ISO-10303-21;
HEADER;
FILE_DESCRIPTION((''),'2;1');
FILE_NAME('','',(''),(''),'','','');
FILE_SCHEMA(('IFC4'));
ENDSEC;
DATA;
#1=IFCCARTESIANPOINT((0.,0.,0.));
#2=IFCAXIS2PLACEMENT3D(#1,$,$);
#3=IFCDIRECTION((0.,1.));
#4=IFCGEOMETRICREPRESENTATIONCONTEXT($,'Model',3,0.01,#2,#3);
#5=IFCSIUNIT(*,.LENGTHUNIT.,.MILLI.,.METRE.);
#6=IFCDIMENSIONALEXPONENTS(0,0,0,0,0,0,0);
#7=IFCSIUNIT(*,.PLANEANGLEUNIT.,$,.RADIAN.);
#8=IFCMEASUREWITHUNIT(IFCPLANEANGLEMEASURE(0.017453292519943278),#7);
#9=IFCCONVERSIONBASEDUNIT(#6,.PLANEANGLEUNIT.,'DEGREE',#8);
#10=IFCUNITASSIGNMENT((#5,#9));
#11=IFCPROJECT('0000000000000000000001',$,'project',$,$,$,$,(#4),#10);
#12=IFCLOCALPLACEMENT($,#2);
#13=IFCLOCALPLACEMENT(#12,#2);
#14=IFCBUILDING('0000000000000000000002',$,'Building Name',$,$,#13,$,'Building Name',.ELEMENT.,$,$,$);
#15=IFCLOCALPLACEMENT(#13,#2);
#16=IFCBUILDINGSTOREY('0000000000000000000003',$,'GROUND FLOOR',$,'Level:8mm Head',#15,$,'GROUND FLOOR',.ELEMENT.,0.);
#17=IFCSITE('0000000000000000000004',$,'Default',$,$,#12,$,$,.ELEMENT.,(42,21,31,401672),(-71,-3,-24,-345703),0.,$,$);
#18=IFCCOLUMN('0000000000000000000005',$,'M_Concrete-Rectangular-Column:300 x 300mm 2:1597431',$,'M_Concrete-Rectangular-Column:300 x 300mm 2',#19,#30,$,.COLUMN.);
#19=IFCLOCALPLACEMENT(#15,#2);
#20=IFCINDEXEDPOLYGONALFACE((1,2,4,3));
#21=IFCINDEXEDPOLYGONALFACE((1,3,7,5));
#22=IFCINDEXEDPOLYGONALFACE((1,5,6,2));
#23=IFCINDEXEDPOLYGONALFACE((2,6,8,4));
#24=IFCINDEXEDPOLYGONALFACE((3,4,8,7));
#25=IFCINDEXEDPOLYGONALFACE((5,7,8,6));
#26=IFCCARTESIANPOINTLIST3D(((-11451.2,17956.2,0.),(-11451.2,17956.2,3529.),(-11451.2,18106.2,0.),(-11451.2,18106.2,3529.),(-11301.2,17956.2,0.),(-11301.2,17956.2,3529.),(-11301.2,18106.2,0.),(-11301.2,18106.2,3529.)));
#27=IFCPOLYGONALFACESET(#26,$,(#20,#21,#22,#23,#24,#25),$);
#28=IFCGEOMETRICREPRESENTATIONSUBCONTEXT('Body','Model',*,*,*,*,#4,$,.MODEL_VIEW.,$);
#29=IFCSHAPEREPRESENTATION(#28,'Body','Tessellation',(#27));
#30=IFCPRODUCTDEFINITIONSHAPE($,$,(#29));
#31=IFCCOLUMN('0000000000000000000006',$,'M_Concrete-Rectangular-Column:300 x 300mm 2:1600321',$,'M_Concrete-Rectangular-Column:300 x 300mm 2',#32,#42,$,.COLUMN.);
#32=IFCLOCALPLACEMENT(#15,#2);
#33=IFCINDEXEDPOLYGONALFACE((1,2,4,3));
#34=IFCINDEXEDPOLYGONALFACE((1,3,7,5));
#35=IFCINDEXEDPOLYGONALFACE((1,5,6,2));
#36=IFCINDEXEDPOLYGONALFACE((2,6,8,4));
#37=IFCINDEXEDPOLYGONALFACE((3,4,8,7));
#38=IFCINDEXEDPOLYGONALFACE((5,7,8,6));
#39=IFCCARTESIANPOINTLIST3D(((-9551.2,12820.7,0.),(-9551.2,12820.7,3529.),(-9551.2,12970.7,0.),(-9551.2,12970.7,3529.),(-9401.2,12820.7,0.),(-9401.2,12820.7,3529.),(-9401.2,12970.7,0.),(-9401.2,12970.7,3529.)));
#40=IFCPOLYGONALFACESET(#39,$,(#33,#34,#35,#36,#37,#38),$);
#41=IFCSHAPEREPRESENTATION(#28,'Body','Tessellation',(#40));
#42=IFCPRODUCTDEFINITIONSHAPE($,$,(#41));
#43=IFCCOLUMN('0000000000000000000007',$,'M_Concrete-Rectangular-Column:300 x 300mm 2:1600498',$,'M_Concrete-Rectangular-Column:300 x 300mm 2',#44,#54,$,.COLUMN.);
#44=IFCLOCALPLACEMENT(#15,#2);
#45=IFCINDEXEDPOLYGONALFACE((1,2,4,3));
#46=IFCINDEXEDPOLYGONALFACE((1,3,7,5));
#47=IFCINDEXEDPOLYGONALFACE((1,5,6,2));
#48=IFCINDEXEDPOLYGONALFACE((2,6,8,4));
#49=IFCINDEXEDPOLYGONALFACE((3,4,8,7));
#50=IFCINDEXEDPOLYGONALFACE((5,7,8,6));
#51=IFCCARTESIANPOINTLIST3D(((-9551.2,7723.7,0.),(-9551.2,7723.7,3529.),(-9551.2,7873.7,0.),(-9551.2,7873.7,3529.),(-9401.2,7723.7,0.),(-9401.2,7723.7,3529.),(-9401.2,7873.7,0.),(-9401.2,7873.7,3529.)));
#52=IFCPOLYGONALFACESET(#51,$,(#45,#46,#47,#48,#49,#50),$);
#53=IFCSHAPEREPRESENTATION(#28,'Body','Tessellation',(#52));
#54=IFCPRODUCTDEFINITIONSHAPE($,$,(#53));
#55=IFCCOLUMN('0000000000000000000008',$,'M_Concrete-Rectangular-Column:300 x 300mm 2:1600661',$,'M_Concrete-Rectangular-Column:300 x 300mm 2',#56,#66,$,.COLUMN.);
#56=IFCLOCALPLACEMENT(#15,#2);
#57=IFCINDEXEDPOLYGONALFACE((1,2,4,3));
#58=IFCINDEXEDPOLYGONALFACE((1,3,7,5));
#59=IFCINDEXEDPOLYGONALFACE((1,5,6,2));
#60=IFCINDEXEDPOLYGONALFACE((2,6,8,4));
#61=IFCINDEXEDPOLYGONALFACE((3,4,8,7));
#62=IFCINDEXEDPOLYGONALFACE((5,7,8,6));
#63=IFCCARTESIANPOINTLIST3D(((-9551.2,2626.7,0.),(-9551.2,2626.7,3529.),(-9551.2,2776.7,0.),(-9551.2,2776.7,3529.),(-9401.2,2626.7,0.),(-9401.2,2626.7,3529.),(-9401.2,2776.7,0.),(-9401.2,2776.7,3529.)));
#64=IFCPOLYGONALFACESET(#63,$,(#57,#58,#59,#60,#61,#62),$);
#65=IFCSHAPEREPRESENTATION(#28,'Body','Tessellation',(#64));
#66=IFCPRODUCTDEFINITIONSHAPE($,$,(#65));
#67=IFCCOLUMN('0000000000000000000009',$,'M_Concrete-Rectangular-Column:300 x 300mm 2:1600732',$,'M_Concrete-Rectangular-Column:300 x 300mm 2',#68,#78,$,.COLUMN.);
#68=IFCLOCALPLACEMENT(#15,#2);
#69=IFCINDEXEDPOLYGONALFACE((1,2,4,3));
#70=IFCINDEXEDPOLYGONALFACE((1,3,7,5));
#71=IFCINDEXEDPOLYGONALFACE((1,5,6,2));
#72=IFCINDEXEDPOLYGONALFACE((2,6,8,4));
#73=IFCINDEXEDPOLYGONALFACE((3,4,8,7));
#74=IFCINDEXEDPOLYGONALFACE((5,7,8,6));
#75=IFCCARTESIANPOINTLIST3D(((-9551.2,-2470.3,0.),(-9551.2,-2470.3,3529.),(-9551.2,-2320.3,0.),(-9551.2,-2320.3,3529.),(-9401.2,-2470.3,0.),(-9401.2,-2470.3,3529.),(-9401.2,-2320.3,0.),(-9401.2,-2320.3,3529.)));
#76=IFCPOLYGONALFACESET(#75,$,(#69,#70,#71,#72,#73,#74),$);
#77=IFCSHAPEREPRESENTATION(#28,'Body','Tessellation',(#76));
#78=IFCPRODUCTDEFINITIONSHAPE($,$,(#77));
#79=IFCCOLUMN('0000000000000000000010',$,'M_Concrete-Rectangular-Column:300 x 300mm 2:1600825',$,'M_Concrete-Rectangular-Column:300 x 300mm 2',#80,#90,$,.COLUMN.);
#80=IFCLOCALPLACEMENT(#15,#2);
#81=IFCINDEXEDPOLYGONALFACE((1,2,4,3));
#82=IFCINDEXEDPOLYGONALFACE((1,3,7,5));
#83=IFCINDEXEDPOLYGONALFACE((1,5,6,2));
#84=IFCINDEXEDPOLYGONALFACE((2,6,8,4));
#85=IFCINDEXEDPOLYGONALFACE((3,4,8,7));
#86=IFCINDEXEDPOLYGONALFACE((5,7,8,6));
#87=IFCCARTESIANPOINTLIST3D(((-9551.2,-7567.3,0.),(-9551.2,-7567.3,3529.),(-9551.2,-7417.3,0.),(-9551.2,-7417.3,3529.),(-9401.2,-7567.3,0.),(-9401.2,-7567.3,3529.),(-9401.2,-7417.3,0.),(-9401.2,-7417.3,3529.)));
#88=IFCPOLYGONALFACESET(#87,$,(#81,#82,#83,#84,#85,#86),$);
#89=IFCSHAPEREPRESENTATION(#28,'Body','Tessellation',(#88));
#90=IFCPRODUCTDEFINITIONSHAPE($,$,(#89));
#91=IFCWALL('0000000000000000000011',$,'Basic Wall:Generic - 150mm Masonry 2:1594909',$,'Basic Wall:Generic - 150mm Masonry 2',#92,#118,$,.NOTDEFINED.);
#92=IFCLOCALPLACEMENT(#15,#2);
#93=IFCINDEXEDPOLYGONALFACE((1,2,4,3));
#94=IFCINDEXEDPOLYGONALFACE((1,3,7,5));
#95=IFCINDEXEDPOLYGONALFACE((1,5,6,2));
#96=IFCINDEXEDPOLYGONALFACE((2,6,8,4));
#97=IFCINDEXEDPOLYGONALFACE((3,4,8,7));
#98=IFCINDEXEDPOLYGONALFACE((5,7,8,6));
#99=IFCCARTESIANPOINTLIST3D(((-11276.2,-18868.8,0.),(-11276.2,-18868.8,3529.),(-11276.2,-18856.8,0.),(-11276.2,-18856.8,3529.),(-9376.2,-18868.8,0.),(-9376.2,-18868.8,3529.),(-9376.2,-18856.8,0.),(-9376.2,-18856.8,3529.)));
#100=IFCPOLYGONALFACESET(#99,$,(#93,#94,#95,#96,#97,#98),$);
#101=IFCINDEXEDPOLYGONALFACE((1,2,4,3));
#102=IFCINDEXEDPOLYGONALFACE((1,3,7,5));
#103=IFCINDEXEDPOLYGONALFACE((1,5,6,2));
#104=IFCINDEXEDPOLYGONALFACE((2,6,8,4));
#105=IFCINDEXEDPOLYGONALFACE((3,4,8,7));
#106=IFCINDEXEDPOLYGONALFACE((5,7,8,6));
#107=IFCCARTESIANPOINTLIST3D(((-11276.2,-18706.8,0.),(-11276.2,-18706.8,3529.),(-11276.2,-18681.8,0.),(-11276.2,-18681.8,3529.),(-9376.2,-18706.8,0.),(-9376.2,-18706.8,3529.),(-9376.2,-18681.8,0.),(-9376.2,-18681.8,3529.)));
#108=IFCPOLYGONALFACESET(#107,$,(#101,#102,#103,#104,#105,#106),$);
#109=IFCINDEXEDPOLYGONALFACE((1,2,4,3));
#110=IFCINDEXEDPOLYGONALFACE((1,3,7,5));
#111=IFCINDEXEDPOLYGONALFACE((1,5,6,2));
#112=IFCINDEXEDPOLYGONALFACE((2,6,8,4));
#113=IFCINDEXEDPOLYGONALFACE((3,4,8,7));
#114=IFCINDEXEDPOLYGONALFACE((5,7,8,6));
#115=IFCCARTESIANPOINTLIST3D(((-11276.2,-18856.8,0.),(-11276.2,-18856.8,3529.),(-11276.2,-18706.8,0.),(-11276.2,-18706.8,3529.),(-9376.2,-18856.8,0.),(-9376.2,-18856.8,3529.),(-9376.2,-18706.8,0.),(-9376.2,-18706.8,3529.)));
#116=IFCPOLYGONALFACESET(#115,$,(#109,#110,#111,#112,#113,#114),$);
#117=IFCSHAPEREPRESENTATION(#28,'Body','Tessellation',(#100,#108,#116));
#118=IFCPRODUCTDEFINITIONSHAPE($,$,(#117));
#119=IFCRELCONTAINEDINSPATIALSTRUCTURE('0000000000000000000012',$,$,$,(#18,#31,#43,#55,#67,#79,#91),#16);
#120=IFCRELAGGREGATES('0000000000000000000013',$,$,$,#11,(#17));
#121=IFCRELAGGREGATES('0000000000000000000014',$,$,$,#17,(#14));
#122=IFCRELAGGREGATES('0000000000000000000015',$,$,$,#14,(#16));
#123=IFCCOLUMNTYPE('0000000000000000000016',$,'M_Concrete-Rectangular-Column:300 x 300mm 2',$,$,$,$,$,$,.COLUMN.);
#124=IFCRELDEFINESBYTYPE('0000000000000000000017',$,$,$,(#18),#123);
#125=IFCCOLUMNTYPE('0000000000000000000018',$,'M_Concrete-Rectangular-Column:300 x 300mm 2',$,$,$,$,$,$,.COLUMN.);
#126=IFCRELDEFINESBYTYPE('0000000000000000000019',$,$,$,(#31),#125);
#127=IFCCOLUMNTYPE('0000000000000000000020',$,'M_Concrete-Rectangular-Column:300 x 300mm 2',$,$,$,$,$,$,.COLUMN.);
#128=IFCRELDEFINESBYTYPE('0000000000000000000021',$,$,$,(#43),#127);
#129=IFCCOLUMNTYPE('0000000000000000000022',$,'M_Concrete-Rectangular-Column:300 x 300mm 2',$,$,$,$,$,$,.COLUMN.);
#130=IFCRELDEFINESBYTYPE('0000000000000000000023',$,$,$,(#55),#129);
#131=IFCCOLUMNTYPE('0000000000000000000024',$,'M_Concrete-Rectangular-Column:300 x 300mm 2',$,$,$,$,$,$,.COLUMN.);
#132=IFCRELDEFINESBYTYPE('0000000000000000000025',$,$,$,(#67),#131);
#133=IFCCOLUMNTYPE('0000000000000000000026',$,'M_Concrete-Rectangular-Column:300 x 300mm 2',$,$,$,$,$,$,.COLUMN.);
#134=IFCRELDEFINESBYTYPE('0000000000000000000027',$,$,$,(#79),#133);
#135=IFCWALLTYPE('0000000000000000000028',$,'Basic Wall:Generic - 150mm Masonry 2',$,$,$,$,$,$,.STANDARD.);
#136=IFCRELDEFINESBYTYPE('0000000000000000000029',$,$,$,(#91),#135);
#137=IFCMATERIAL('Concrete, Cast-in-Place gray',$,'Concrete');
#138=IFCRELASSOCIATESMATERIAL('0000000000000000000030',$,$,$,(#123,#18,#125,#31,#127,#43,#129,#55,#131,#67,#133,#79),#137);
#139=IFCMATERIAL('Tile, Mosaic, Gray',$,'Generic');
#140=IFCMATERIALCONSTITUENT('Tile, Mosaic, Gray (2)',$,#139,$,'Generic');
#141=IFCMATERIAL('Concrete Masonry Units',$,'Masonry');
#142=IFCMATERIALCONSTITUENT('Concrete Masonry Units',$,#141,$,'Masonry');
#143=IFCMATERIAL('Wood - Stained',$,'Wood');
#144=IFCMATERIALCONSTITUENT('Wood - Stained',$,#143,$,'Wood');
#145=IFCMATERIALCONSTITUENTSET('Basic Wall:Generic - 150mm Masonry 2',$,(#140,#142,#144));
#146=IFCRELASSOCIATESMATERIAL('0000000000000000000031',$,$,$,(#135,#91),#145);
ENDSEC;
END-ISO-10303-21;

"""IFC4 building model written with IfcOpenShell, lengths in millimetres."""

from ifc_helpers import new_model, entity, si_unit, converted_unit, direction, frame, origin, place, context, subcontext, project, spatial, indexed_curve, outline, extrude, source, transform, mapped, material, constituent, constituent_set, type_object, type_shapes, element, save


model = new_model("IFC4")

# Units and contexts
model_context = context("Model", 3, precision=0.01, world=origin(), true_north=direction((0.0, 1.0)))
body_context = subcontext(model_context, "Body", "Model", "MODEL_VIEW")
ifc_project = project(units=[si_unit("LENGTHUNIT", "METRE", prefix="MILLI"), converted_unit("PLANEANGLEUNIT", "DEGREE", entity("IfcPlaneAngleMeasure", 0.017453292519943278), si_unit("PLANEANGLEUNIT", "RADIAN"), dimensions=[0, 0, 0, 0, 0, 0, 0])], contexts=[model_context])

# Site, building, storey
site_placement = place(None, origin())
site = spatial("IfcSite", under=ifc_project, at=site_placement, Name="Default", CompositionType="ELEMENT", RefLatitude=(42, 21, 31, 401672), RefLongitude=(-71, -3, -24, -345703), RefElevation=0.0)
building_placement = place(site_placement, origin())
building = spatial("IfcBuilding", under=site, at=building_placement, Name="Building Name", LongName="Building Name", CompositionType="ELEMENT")
storey_placement = place(building_placement, origin())
storey = spatial("IfcBuildingStorey", under=building, at=storey_placement, Name="GROUND FLOOR", ObjectType="Level:8mm Head", LongName="GROUND FLOOR", CompositionType="ELEMENT", Elevation=0.0)

# Columns
ifc_material_1 = material(Name="Concrete, Cast-in-Place gray", Category="Concrete")
column_type_1 = type_object("IfcColumnType", Name="M_Concrete-Rectangular-Column:300 x 300mm 2", PredefinedType="COLUMN", material=ifc_material_1)
shared_shape_1 = source(origin(), body_context, "Body", "SweptSolid", [
    extrude(outline(indexed_curve([(-75.0, -75.0), (75.0, -75.0), (75.0, 75.0), (-75.0, 75.0), (-75.0, -75.0)], self_intersect=False)), frame((-11376.2, 18031.2, 0.0), z_axis=(0.0, 0.0, 1.0), x_axis=(-1.0, 0.0, 0.0)), (0.0, 0.0, 1.0), 3529.0),
])
type_shapes(column_type_1, [shared_shape_1])
column_1_placement = place(storey_placement, origin())
element("IfcColumn", 1, at=column_1_placement, inside=storey, type_object=column_type_1, material=ifc_material_1, Name="M_Concrete-Rectangular-Column:300 x 300mm 2:1597431", ObjectType="M_Concrete-Rectangular-Column:300 x 300mm 2", PredefinedType="COLUMN", context=body_context, shape_type="MappedRepresentation", body=[
    mapped(shared_shape_1, transform((0.0, 0.0, 0.0), scale=1.0)),
])
column_type_2 = type_object("IfcColumnType", Name="M_Concrete-Rectangular-Column:300 x 300mm 2", PredefinedType="COLUMN", material=ifc_material_1)
shared_shape_2 = source(origin(), body_context, "Body", "SweptSolid", [
    extrude(outline(indexed_curve([(-75.0, -75.0), (75.0, -75.0), (75.0, 75.0), (-75.0, 75.0), (-75.0, -75.0)], self_intersect=False)), frame((-9476.2, 12895.7, 0.0), z_axis=(0.0, 0.0, 1.0), x_axis=(-1.0, 0.0, 0.0)), (0.0, 0.0, 1.0), 3529.0),
])
type_shapes(column_type_2, [shared_shape_2])
column_2_placement = place(storey_placement, origin())
element("IfcColumn", 2, at=column_2_placement, inside=storey, type_object=column_type_2, material=ifc_material_1, Name="M_Concrete-Rectangular-Column:300 x 300mm 2:1600321", ObjectType="M_Concrete-Rectangular-Column:300 x 300mm 2", PredefinedType="COLUMN", context=body_context, shape_type="MappedRepresentation", body=[
    mapped(shared_shape_2, transform((0.0, 0.0, 0.0), scale=1.0)),
])
column_type_3 = type_object("IfcColumnType", Name="M_Concrete-Rectangular-Column:300 x 300mm 2", PredefinedType="COLUMN", material=ifc_material_1)
shared_shape_3 = source(origin(), body_context, "Body", "SweptSolid", [
    extrude(outline(indexed_curve([(-75.0, -75.0), (75.0, -75.0), (75.0, 75.0), (-75.0, 75.0), (-75.0, -75.0)], self_intersect=False)), frame((-9476.2, 7798.7, 0.0), z_axis=(0.0, 0.0, 1.0), x_axis=(-1.0, 0.0, 0.0)), (0.0, 0.0, 1.0), 3529.0),
])
type_shapes(column_type_3, [shared_shape_3])
column_3_placement = place(storey_placement, origin())
element("IfcColumn", 3, at=column_3_placement, inside=storey, type_object=column_type_3, material=ifc_material_1, Name="M_Concrete-Rectangular-Column:300 x 300mm 2:1600498", ObjectType="M_Concrete-Rectangular-Column:300 x 300mm 2", PredefinedType="COLUMN", context=body_context, shape_type="MappedRepresentation", body=[
    mapped(shared_shape_3, transform((0.0, 0.0, 0.0), scale=1.0)),
])
column_type_4 = type_object("IfcColumnType", Name="M_Concrete-Rectangular-Column:300 x 300mm 2", PredefinedType="COLUMN", material=ifc_material_1)
shared_shape_4 = source(origin(), body_context, "Body", "SweptSolid", [
    extrude(outline(indexed_curve([(-75.0, -75.0), (75.0, -75.0), (75.0, 75.0), (-75.0, 75.0), (-75.0, -75.0)], self_intersect=False)), frame((-9476.2, 2701.7, 0.0), z_axis=(0.0, 0.0, 1.0), x_axis=(-1.0, 0.0, 0.0)), (0.0, 0.0, 1.0), 3529.0),
])
type_shapes(column_type_4, [shared_shape_4])
column_4_placement = place(storey_placement, origin())
element("IfcColumn", 4, at=column_4_placement, inside=storey, type_object=column_type_4, material=ifc_material_1, Name="M_Concrete-Rectangular-Column:300 x 300mm 2:1600661", ObjectType="M_Concrete-Rectangular-Column:300 x 300mm 2", PredefinedType="COLUMN", context=body_context, shape_type="MappedRepresentation", body=[
    mapped(shared_shape_4, transform((0.0, 0.0, 0.0), scale=1.0)),
])
column_type_5 = type_object("IfcColumnType", Name="M_Concrete-Rectangular-Column:300 x 300mm 2", PredefinedType="COLUMN", material=ifc_material_1)
shared_shape_5 = source(origin(), body_context, "Body", "SweptSolid", [
    extrude(outline(indexed_curve([(-75.0, -75.0), (75.0, -75.0), (75.0, 75.0), (-75.0, 75.0), (-75.0, -75.0)], self_intersect=False)), frame((-9476.2, -2395.3, 0.0), z_axis=(0.0, 0.0, 1.0), x_axis=(-1.0, 0.0, 0.0)), (0.0, 0.0, 1.0), 3529.0),
])
type_shapes(column_type_5, [shared_shape_5])
column_5_placement = place(storey_placement, origin())
element("IfcColumn", 5, at=column_5_placement, inside=storey, type_object=column_type_5, material=ifc_material_1, Name="M_Concrete-Rectangular-Column:300 x 300mm 2:1600732", ObjectType="M_Concrete-Rectangular-Column:300 x 300mm 2", PredefinedType="COLUMN", context=body_context, shape_type="MappedRepresentation", body=[
    mapped(shared_shape_5, transform((0.0, 0.0, 0.0), scale=1.0)),
])
column_type_6 = type_object("IfcColumnType", Name="M_Concrete-Rectangular-Column:300 x 300mm 2", PredefinedType="COLUMN", material=ifc_material_1)
shared_shape_6 = source(origin(), body_context, "Body", "SweptSolid", [
    extrude(outline(indexed_curve([(-75.0, -75.0), (75.0, -75.0), (75.0, 75.0), (-75.0, 75.0), (-75.0, -75.0)], self_intersect=False)), frame((-9476.2, -7492.3, 0.0), z_axis=(0.0, 0.0, 1.0), x_axis=(-1.0, 0.0, 0.0)), (0.0, 0.0, 1.0), 3529.0),
])
type_shapes(column_type_6, [shared_shape_6])
column_6_placement = place(storey_placement, origin())
element("IfcColumn", 6, at=column_6_placement, inside=storey, type_object=column_type_6, material=ifc_material_1, Name="M_Concrete-Rectangular-Column:300 x 300mm 2:1600825", ObjectType="M_Concrete-Rectangular-Column:300 x 300mm 2", PredefinedType="COLUMN", context=body_context, shape_type="MappedRepresentation", body=[
    mapped(shared_shape_6, transform((0.0, 0.0, 0.0), scale=1.0)),
])

# Wall
ifc_material_2 = material(Name="Tile, Mosaic, Gray", Category="Generic")
ifc_constituent_1 = constituent(ifc_material_2, Name="Tile, Mosaic, Gray (2)", Category="Generic")
ifc_material_3 = material(Name="Concrete Masonry Units", Category="Masonry")
ifc_constituent_2 = constituent(ifc_material_3, Name="Concrete Masonry Units", Category="Masonry")
ifc_material_4 = material(Name="Wood - Stained", Category="Wood")
ifc_constituent_3 = constituent(ifc_material_4, Name="Wood - Stained", Category="Wood")
ifc_constituent_set_1 = constituent_set(constituents=[ifc_constituent_1, ifc_constituent_2, ifc_constituent_3], Name="Basic Wall:Generic - 150mm Masonry 2")
wall_type_1 = type_object("IfcWallType", Name="Basic Wall:Generic - 150mm Masonry 2", PredefinedType="STANDARD", material=ifc_constituent_set_1)
wall_1_placement = place(storey_placement, frame((-11276.2, -18775.3, 0.0)))
element("IfcWall", 7, at=wall_1_placement, inside=storey, type_object=wall_type_1, material=ifc_constituent_set_1, Name="Basic Wall:Generic - 150mm Masonry 2:1594909", ObjectType="Basic Wall:Generic - 150mm Masonry 2", PredefinedType="NOTDEFINED", context=body_context, shape_type="SweptSolid", body=[
    extrude(outline(indexed_curve([(-6.0, -950.0), (6.0, -950.0), (6.0, 950.0), (-6.0, 950.0), (-6.0, -950.0)], self_intersect=False)), frame((950.0, -87.5, 0.0), z_axis=(0.0, 0.0, 1.0), x_axis=(0.0, 1.0, 0.0)), (0.0, 0.0, 1.0), 3529.0),
    extrude(outline(indexed_curve([(-12.5, -950.0), (12.5, -950.0), (12.5, 950.0), (-12.5, 950.0), (-12.5, -950.0)], self_intersect=False)), frame((950.0, 81.0, 0.0), z_axis=(0.0, 0.0, 1.0), x_axis=(0.0, -1.0, 0.0)), (0.0, 0.0, 1.0), 3529.0),
    extrude(outline(indexed_curve([(-950.0, -75.0), (950.0, -75.0), (950.0, 75.0), (-950.0, 75.0), (-950.0, -75.0)], self_intersect=False)), frame((950.0, -6.5, 0.0)), (0.0, 0.0, 1.0), 3529.0),
])

save(model, "model.ifc")
